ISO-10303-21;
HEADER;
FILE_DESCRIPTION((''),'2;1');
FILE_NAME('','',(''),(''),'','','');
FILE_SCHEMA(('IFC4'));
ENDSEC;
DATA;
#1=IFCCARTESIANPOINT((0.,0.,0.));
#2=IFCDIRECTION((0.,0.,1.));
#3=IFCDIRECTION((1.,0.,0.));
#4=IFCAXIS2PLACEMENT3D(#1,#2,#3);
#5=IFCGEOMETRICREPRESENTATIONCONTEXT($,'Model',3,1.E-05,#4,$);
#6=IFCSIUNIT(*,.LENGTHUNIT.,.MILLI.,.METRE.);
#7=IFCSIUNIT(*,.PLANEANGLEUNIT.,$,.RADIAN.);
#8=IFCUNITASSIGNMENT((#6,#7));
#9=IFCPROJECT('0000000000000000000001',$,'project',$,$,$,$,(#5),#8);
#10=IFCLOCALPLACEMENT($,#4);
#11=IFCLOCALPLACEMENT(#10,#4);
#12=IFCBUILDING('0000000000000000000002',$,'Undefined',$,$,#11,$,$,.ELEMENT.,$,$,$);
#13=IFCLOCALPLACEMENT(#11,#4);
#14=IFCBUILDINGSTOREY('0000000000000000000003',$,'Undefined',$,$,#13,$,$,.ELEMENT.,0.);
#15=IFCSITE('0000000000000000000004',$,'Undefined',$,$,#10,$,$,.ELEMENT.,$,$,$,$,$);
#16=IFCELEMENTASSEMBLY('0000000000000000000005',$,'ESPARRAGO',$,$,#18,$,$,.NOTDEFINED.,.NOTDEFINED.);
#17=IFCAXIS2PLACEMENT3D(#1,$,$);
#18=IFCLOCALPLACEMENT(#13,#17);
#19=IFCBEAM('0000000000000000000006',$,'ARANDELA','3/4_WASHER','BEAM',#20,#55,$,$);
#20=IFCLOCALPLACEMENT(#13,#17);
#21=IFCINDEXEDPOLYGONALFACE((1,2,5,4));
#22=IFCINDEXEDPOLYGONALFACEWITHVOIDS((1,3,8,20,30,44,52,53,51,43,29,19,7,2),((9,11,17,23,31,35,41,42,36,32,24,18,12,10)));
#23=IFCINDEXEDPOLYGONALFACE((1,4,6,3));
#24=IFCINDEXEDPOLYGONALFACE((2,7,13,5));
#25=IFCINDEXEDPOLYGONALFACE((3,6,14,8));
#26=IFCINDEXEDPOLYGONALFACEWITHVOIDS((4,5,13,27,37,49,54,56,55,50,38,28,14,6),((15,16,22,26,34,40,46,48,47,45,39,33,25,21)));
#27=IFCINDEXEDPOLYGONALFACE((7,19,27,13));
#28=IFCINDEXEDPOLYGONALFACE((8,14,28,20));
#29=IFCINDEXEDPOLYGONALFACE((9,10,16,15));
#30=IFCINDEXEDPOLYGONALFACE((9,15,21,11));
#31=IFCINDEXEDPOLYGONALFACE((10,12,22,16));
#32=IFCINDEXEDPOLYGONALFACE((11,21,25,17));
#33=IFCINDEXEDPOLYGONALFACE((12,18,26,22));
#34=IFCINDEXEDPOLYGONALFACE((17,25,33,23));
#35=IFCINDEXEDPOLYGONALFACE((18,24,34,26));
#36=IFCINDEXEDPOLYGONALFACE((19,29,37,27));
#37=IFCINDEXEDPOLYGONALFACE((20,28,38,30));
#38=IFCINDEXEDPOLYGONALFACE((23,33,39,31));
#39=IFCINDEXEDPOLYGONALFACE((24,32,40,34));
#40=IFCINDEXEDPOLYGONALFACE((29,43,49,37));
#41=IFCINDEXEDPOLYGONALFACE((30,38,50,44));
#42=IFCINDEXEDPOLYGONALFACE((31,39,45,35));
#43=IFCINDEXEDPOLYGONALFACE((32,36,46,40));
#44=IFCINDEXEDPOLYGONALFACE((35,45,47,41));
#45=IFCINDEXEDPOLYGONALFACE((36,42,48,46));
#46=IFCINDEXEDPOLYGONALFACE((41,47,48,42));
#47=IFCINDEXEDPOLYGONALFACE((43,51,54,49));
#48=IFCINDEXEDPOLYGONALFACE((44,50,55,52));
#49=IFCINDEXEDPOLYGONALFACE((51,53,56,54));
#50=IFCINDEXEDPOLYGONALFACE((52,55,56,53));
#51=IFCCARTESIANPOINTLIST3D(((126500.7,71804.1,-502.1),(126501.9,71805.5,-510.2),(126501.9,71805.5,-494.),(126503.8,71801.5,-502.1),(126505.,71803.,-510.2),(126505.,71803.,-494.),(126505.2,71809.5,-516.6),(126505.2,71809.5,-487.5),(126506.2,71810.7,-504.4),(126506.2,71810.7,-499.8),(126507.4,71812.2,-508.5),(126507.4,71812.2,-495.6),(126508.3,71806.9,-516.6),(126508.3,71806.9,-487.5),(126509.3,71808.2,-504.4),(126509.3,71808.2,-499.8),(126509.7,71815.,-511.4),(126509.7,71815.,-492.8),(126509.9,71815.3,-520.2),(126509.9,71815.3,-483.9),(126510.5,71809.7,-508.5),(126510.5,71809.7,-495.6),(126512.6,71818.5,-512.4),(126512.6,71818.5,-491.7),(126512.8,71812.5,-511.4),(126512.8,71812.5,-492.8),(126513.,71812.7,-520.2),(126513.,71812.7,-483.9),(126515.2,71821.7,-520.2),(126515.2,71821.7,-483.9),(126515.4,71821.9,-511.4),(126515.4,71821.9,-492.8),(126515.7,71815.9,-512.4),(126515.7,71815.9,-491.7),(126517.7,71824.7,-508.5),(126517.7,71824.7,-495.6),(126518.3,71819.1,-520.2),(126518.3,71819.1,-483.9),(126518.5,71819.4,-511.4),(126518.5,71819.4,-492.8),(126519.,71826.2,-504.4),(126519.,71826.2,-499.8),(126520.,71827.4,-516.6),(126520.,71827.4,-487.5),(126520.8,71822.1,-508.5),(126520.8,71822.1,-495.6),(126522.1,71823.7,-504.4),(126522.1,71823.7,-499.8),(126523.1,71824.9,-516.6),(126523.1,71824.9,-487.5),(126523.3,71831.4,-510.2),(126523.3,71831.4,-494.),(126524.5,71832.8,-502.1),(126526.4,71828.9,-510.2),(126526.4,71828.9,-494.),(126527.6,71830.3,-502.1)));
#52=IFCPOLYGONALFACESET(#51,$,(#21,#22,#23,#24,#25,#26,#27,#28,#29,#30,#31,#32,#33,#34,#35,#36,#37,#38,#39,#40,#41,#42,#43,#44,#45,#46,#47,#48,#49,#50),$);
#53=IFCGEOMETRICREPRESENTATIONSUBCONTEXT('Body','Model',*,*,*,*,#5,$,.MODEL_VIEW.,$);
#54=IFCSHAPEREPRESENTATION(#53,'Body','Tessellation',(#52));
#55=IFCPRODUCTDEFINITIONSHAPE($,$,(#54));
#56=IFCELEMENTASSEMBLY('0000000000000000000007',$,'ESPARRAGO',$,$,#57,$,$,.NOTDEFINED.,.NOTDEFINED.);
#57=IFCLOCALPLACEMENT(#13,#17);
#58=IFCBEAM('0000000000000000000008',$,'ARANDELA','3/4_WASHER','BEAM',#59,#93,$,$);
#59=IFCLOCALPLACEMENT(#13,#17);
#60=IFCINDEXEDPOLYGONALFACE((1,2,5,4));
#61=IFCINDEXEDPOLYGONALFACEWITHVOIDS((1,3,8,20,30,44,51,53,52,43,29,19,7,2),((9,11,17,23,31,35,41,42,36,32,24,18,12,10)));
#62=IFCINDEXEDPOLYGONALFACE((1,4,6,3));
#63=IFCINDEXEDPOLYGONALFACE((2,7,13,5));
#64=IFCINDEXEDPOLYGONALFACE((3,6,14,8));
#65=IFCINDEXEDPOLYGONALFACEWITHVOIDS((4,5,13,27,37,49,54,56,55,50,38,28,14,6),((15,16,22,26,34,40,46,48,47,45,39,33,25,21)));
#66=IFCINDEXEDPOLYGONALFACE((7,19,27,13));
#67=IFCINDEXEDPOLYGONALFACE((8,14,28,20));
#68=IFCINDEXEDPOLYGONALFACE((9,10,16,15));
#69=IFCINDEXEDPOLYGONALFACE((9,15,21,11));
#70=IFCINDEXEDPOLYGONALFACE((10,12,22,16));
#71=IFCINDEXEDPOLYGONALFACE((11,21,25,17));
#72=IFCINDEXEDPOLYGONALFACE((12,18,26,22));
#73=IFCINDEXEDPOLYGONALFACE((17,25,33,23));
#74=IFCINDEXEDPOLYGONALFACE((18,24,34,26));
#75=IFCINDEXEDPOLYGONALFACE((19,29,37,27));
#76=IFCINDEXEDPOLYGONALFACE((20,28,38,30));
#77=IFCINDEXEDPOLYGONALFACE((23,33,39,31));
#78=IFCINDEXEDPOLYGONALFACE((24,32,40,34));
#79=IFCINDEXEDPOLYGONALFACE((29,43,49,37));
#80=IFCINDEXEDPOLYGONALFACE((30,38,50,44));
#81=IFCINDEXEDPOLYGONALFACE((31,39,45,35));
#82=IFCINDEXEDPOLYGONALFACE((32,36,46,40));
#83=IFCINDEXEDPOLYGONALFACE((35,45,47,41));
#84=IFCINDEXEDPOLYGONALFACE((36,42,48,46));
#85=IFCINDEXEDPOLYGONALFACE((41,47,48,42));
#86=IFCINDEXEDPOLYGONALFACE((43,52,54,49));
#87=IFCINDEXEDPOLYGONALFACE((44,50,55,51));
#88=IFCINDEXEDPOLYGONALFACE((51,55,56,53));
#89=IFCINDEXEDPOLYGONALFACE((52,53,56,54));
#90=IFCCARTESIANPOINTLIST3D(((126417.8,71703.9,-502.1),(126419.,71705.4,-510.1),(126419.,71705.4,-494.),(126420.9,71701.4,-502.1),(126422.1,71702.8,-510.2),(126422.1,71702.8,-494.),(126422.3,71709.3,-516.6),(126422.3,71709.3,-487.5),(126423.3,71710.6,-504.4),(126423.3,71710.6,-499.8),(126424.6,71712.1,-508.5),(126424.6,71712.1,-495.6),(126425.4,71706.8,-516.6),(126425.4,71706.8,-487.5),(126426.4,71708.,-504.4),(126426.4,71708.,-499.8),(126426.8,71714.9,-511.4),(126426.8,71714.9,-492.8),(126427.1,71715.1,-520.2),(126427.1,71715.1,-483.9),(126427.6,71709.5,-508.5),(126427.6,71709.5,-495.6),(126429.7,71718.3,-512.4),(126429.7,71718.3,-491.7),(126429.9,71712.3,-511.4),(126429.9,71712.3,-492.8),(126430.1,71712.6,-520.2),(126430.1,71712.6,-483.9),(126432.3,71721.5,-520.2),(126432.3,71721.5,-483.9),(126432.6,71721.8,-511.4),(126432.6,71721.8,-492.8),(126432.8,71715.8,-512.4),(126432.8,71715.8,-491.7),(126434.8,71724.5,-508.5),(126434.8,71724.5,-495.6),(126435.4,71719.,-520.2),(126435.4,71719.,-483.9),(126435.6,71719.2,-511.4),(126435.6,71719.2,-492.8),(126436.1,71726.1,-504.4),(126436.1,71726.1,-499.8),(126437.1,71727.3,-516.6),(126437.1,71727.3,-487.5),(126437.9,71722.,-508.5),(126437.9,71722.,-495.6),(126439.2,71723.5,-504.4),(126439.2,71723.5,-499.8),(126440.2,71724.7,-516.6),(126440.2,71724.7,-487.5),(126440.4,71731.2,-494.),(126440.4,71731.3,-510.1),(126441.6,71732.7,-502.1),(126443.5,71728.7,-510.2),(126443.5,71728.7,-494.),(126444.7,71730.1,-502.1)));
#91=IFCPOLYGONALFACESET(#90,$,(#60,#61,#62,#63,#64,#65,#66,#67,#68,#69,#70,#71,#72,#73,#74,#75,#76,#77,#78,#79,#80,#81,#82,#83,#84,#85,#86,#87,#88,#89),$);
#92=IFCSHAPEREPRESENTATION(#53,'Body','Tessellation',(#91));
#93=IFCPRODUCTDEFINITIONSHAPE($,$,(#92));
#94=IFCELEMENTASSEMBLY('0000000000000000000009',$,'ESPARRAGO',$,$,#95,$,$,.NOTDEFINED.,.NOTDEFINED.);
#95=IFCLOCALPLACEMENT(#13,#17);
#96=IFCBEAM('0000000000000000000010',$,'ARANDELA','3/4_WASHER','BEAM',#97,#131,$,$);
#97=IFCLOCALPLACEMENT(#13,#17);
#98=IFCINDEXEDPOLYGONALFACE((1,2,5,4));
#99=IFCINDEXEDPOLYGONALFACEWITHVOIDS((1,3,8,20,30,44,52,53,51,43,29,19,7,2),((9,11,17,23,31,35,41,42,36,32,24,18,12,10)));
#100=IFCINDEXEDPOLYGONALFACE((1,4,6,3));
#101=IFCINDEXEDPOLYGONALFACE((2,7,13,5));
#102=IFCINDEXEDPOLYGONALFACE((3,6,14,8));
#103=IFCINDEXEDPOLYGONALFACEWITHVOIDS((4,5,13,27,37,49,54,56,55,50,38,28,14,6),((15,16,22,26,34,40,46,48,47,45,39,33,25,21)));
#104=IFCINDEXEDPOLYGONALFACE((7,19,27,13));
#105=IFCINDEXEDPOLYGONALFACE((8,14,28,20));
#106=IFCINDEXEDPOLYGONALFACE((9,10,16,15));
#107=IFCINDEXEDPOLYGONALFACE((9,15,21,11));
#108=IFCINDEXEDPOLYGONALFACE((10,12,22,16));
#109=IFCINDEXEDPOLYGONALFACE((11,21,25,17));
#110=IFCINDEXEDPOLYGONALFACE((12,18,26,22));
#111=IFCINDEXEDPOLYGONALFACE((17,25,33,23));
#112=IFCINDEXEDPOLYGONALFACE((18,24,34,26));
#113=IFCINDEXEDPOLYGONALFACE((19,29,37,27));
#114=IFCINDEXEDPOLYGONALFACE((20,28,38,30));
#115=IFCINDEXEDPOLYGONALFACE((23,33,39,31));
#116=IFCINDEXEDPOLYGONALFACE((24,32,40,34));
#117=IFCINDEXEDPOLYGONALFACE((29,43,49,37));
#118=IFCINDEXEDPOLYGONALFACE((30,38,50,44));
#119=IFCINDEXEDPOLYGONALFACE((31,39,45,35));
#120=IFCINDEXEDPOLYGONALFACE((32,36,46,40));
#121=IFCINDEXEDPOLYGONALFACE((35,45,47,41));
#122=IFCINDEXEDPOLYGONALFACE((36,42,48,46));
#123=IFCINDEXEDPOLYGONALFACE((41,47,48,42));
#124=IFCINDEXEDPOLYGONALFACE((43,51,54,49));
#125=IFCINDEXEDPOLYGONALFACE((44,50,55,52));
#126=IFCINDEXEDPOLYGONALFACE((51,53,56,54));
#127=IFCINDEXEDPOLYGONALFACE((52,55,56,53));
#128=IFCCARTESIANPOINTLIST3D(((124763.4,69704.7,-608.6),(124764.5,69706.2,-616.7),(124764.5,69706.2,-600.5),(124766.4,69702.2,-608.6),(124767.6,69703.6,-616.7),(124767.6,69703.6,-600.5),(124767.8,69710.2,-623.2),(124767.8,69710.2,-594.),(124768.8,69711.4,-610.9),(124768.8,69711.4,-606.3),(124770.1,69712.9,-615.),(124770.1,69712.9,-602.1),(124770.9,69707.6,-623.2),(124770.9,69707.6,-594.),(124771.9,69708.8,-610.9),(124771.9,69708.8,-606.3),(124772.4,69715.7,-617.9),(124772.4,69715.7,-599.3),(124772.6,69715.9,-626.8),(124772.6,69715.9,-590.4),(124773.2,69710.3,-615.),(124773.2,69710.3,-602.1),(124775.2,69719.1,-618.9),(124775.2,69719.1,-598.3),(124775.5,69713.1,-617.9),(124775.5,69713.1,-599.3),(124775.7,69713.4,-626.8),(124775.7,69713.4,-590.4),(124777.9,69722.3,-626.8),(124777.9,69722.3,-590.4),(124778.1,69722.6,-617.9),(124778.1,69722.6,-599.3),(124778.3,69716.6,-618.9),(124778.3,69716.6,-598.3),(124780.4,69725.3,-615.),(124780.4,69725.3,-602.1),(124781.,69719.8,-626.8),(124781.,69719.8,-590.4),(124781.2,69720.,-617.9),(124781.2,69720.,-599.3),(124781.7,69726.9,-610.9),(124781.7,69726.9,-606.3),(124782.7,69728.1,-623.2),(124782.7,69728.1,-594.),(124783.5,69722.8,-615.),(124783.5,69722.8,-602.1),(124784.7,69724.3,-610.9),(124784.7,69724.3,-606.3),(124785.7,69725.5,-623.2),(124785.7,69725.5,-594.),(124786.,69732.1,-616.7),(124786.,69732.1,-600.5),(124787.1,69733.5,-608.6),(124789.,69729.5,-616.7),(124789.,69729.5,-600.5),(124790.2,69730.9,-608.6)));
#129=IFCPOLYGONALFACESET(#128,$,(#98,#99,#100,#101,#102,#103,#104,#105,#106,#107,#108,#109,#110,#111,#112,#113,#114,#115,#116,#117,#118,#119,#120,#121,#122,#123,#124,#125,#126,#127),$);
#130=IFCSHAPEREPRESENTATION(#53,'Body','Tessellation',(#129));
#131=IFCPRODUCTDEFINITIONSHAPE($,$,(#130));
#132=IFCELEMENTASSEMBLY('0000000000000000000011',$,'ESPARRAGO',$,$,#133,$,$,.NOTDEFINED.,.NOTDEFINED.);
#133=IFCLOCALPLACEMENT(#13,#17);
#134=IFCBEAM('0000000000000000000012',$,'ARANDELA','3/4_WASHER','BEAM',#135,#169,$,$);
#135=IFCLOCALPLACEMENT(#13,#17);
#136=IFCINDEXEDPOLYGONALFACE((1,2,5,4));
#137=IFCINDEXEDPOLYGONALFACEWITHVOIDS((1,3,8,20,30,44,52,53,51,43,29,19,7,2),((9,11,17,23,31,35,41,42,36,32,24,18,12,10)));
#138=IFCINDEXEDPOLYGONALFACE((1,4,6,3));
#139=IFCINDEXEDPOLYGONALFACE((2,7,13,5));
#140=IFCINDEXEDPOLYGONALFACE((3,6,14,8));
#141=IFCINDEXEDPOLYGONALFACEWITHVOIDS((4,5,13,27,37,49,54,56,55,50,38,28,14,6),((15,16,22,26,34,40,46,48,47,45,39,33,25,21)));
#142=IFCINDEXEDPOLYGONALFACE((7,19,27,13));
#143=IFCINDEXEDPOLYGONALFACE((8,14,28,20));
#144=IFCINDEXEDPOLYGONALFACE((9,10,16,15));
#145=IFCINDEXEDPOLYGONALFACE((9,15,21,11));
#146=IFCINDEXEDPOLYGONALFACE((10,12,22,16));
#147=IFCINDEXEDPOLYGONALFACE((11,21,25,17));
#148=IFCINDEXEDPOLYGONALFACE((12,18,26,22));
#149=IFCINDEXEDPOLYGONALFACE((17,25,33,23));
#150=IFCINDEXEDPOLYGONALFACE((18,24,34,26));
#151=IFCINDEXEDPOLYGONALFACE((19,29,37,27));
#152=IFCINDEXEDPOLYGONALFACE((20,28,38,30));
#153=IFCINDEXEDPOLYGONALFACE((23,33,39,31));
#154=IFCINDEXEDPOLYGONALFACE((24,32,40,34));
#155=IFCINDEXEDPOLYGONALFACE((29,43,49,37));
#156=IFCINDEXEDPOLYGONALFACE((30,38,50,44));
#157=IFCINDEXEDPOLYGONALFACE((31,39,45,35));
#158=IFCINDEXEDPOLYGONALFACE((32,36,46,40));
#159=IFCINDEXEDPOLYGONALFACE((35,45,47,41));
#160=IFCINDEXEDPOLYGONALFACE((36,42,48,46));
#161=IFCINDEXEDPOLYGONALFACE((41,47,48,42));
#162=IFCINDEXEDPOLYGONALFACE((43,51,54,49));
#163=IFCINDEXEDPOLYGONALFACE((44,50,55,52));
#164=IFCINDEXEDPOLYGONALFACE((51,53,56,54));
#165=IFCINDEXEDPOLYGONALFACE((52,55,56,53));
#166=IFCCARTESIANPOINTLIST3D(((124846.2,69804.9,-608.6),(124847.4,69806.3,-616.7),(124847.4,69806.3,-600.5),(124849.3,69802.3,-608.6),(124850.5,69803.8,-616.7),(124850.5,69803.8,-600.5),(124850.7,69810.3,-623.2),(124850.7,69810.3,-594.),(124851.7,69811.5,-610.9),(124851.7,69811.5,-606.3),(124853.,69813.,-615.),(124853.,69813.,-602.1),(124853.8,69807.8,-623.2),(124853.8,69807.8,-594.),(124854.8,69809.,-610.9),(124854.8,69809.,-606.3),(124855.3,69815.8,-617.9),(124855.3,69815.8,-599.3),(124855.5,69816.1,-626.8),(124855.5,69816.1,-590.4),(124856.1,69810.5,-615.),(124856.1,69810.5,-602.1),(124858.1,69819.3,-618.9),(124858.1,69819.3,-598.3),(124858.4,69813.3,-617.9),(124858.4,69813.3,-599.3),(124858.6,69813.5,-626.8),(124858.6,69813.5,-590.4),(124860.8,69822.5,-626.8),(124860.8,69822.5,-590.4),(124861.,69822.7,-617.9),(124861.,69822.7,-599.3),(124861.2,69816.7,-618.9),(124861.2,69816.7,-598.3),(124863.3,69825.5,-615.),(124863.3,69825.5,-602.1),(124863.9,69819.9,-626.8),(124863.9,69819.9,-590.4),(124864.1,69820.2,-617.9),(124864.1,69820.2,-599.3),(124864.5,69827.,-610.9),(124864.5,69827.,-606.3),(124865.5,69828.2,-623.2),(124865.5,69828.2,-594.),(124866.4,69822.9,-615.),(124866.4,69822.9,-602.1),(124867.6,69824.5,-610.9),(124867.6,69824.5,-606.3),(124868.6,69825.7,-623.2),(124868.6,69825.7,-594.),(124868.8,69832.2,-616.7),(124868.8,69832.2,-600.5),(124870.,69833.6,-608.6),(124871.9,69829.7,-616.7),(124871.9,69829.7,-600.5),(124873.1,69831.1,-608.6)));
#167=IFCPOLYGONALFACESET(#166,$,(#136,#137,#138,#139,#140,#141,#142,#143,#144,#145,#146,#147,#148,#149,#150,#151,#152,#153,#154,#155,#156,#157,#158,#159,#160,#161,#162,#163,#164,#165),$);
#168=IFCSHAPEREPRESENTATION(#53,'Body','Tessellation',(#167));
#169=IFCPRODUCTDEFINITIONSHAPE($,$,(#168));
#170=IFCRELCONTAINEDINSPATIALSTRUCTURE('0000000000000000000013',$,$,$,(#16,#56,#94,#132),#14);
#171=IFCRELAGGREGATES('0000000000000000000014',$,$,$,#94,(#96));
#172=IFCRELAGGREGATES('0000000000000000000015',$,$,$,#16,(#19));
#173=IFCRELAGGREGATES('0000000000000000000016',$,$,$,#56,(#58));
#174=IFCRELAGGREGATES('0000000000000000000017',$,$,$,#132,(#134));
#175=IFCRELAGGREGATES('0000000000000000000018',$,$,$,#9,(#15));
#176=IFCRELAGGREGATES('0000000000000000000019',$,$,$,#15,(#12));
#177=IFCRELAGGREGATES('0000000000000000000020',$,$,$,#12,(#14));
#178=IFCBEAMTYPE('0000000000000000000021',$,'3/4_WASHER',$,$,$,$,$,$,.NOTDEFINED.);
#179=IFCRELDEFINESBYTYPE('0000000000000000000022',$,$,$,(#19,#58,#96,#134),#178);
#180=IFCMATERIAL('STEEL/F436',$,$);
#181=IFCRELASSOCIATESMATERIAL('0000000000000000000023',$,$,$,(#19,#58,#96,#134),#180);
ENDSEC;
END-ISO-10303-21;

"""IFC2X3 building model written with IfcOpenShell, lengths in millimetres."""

from ifc_helpers import new_model, si_unit, frame, origin_with_axes, place, context, subcontext, project, spatial, polyline, outline, extrude, material, type_object, element, aggregate, save


model = new_model("IFC2X3")

# Units and contexts
model_context = context("Model", 3, precision=1e-05, world=origin_with_axes())
body_context = subcontext(model_context, "Body", "Model", "MODEL_VIEW")
ifc_project = project(units=[si_unit("LENGTHUNIT", "METRE", prefix="MILLI"), si_unit("PLANEANGLEUNIT", "RADIAN")], contexts=[model_context])

# Site, building, storey
site_placement = place(None, origin_with_axes())
site = spatial("IfcSite", under=ifc_project, at=site_placement, Name="Undefined", CompositionType="ELEMENT")
building_placement = place(site_placement, origin_with_axes())
building = spatial("IfcBuilding", under=site, at=building_placement, Name="Undefined", CompositionType="ELEMENT")
storey_placement = place(building_placement, origin_with_axes())
storey = spatial("IfcBuildingStorey", under=building, at=storey_placement, Name="Undefined", CompositionType="ELEMENT", Elevation=0.0)

# Element assemblies, beams
ifc_material_1 = material(Name="STEEL/F436")
beam_type_1 = type_object("IfcBeamType", Name="3/4_WASHER", PredefinedType="NOTDEFINED")
assembly_1_placement = place(storey_placement, origin_with_axes())
assembly_1 = element("IfcElementAssembly", 1, at=assembly_1_placement, inside=storey, Name="ESPARRAGO", AssemblyPlace="NOTDEFINED", PredefinedType="NOTDEFINED")
beam_1_placement = place(assembly_1_placement, frame((126512.6, 71818.5, -502.1), z_axis=(0.000066, -0.000055, 1.0), x_axis=(0.7704, -0.637561, -0.000086)))
beam_1 = element("IfcBeam", 2, at=beam_1_placement, type_object=beam_type_1, material=ifc_material_1, Name="ARANDELA", Description="3/4_WASHER", ObjectType="BEAM", context=body_context, shape_type="SweptSolid", body=[
    extrude(outline(polyline([(-11.6, -14.6), (-16.8, -8.1), (-18.6, 0.0), (-16.8, 8.1), (-11.6, 14.6), (-4.2, 18.2), (4.2, 18.2), (11.6, 14.6), (16.8, 8.1), (18.6, 0.0), (16.8, -8.1), (11.6, -14.6), (4.2, -18.2), (-4.2, -18.2), (-11.6, -14.6)]), holes=[polyline([(-4.5, 9.3), (-8.1, 6.4), (-10.1, 2.3), (-10.1, -2.3), (-8.1, -6.4), (-4.5, -9.3), (0.0, -10.3), (4.5, -9.3), (8.1, -6.4), (10.1, -2.3), (10.1, 2.3), (8.1, 6.4), (4.5, 9.3), (0.0, 10.3), (-4.5, 9.3)])]), frame((4.0, 0.0, 0.0), z_axis=(-1.0, 0.0, 0.0), x_axis=(0.0, -1.0, 0.0)), (0.0, 0.0, 1.0), 4.0),
])
assembly_2_placement = place(storey_placement, origin_with_axes())
assembly_2 = element("IfcElementAssembly", 3, at=assembly_2_placement, inside=storey, Name="ESPARRAGO", AssemblyPlace="NOTDEFINED", PredefinedType="NOTDEFINED")
beam_2_placement = place(assembly_2_placement, frame((126429.7, 71718.3, -502.1), z_axis=(0.000066, -0.000055, 1.0), x_axis=(0.7704, -0.637561, -0.000086)))
beam_2 = element("IfcBeam", 4, at=beam_2_placement, type_object=beam_type_1, material=ifc_material_1, Name="ARANDELA", Description="3/4_WASHER", ObjectType="BEAM", context=body_context, shape_type="SweptSolid", body=[
    extrude(outline(polyline([(-11.6, -14.6), (-16.8, -8.1), (-18.6, 0.0), (-16.8, 8.1), (-11.6, 14.6), (-4.2, 18.2), (4.2, 18.2), (11.6, 14.6), (16.8, 8.1), (18.6, 0.0), (16.8, -8.1), (11.6, -14.6), (4.2, -18.2), (-4.2, -18.2), (-11.6, -14.6)]), holes=[polyline([(-4.5, 9.3), (-8.1, 6.4), (-10.1, 2.3), (-10.1, -2.3), (-8.1, -6.4), (-4.5, -9.3), (0.0, -10.3), (4.5, -9.3), (8.1, -6.4), (10.1, -2.3), (10.1, 2.3), (8.1, 6.4), (4.5, 9.3), (0.0, 10.3), (-4.5, 9.3)])]), frame((4.0, 0.0, 0.0), z_axis=(-1.0, 0.0, 0.0), x_axis=(0.0, -1.0, 0.0)), (0.0, 0.0, 1.0), 4.0),
])
assembly_3_placement = place(storey_placement, origin_with_axes())
assembly_3 = element("IfcElementAssembly", 5, at=assembly_3_placement, inside=storey, Name="ESPARRAGO", AssemblyPlace="NOTDEFINED", PredefinedType="NOTDEFINED")
beam_3_placement = place(assembly_3_placement, frame((124775.2, 69719.1, -608.6), z_axis=(0.000066, -0.000055, 1.0), x_axis=(0.7704, -0.637561, -0.000086)))
beam_3 = element("IfcBeam", 6, at=beam_3_placement, type_object=beam_type_1, material=ifc_material_1, Name="ARANDELA", Description="3/4_WASHER", ObjectType="BEAM", context=body_context, shape_type="SweptSolid", body=[
    extrude(outline(polyline([(-11.6, -14.6), (-16.8, -8.1), (-18.6, 0.0), (-16.8, 8.1), (-11.6, 14.6), (-4.2, 18.2), (4.2, 18.2), (11.6, 14.6), (16.8, 8.1), (18.6, 0.0), (16.8, -8.1), (11.6, -14.6), (4.2, -18.2), (-4.2, -18.2), (-11.6, -14.6)]), holes=[polyline([(-4.5, 9.3), (-8.1, 6.4), (-10.1, 2.3), (-10.1, -2.3), (-8.1, -6.4), (-4.5, -9.3), (0.0, -10.3), (4.5, -9.3), (8.1, -6.4), (10.1, -2.3), (10.1, 2.3), (8.1, 6.4), (4.5, 9.3), (0.0, 10.3), (-4.5, 9.3)])]), frame((4.0, 0.0, 0.0), z_axis=(-1.0, 0.0, 0.0), x_axis=(0.0, -1.0, 0.0)), (0.0, 0.0, 1.0), 4.0),
])
aggregate(assembly_3, [beam_3])
assembly_4_placement = place(storey_placement, origin_with_axes())
assembly_4 = element("IfcElementAssembly", 7, at=assembly_4_placement, inside=storey, Name="ESPARRAGO", AssemblyPlace="NOTDEFINED", PredefinedType="NOTDEFINED")
beam_4_placement = place(assembly_4_placement, frame((124858.1, 69819.3, -608.6), z_axis=(0.000066, -0.000055, 1.0), x_axis=(0.7704, -0.637561, -0.000086)))
beam_4 = element("IfcBeam", 8, at=beam_4_placement, type_object=beam_type_1, material=ifc_material_1, Name="ARANDELA", Description="3/4_WASHER", ObjectType="BEAM", context=body_context, shape_type="SweptSolid", body=[
    extrude(outline(polyline([(-11.6, -14.6), (-16.8, -8.1), (-18.6, 0.0), (-16.8, 8.1), (-11.6, 14.6), (-4.2, 18.2), (4.2, 18.2), (11.6, 14.6), (16.8, 8.1), (18.6, 0.0), (16.8, -8.1), (11.6, -14.6), (4.2, -18.2), (-4.2, -18.2), (-11.6, -14.6)]), holes=[polyline([(-4.5, 9.3), (-8.1, 6.4), (-10.1, 2.3), (-10.1, -2.3), (-8.1, -6.4), (-4.5, -9.3), (0.0, -10.3), (4.5, -9.3), (8.1, -6.4), (10.1, -2.3), (10.1, 2.3), (8.1, 6.4), (4.5, 9.3), (0.0, 10.3), (-4.5, 9.3)])]), frame((4.0, 0.0, 0.0), z_axis=(-1.0, 0.0, 0.0), x_axis=(0.0, -1.0, 0.0)), (0.0, 0.0, 1.0), 4.0),
])

aggregate(assembly_1, [beam_1])
aggregate(assembly_2, [beam_2])
aggregate(assembly_4, [beam_4])

save(model, "model.ifc")
